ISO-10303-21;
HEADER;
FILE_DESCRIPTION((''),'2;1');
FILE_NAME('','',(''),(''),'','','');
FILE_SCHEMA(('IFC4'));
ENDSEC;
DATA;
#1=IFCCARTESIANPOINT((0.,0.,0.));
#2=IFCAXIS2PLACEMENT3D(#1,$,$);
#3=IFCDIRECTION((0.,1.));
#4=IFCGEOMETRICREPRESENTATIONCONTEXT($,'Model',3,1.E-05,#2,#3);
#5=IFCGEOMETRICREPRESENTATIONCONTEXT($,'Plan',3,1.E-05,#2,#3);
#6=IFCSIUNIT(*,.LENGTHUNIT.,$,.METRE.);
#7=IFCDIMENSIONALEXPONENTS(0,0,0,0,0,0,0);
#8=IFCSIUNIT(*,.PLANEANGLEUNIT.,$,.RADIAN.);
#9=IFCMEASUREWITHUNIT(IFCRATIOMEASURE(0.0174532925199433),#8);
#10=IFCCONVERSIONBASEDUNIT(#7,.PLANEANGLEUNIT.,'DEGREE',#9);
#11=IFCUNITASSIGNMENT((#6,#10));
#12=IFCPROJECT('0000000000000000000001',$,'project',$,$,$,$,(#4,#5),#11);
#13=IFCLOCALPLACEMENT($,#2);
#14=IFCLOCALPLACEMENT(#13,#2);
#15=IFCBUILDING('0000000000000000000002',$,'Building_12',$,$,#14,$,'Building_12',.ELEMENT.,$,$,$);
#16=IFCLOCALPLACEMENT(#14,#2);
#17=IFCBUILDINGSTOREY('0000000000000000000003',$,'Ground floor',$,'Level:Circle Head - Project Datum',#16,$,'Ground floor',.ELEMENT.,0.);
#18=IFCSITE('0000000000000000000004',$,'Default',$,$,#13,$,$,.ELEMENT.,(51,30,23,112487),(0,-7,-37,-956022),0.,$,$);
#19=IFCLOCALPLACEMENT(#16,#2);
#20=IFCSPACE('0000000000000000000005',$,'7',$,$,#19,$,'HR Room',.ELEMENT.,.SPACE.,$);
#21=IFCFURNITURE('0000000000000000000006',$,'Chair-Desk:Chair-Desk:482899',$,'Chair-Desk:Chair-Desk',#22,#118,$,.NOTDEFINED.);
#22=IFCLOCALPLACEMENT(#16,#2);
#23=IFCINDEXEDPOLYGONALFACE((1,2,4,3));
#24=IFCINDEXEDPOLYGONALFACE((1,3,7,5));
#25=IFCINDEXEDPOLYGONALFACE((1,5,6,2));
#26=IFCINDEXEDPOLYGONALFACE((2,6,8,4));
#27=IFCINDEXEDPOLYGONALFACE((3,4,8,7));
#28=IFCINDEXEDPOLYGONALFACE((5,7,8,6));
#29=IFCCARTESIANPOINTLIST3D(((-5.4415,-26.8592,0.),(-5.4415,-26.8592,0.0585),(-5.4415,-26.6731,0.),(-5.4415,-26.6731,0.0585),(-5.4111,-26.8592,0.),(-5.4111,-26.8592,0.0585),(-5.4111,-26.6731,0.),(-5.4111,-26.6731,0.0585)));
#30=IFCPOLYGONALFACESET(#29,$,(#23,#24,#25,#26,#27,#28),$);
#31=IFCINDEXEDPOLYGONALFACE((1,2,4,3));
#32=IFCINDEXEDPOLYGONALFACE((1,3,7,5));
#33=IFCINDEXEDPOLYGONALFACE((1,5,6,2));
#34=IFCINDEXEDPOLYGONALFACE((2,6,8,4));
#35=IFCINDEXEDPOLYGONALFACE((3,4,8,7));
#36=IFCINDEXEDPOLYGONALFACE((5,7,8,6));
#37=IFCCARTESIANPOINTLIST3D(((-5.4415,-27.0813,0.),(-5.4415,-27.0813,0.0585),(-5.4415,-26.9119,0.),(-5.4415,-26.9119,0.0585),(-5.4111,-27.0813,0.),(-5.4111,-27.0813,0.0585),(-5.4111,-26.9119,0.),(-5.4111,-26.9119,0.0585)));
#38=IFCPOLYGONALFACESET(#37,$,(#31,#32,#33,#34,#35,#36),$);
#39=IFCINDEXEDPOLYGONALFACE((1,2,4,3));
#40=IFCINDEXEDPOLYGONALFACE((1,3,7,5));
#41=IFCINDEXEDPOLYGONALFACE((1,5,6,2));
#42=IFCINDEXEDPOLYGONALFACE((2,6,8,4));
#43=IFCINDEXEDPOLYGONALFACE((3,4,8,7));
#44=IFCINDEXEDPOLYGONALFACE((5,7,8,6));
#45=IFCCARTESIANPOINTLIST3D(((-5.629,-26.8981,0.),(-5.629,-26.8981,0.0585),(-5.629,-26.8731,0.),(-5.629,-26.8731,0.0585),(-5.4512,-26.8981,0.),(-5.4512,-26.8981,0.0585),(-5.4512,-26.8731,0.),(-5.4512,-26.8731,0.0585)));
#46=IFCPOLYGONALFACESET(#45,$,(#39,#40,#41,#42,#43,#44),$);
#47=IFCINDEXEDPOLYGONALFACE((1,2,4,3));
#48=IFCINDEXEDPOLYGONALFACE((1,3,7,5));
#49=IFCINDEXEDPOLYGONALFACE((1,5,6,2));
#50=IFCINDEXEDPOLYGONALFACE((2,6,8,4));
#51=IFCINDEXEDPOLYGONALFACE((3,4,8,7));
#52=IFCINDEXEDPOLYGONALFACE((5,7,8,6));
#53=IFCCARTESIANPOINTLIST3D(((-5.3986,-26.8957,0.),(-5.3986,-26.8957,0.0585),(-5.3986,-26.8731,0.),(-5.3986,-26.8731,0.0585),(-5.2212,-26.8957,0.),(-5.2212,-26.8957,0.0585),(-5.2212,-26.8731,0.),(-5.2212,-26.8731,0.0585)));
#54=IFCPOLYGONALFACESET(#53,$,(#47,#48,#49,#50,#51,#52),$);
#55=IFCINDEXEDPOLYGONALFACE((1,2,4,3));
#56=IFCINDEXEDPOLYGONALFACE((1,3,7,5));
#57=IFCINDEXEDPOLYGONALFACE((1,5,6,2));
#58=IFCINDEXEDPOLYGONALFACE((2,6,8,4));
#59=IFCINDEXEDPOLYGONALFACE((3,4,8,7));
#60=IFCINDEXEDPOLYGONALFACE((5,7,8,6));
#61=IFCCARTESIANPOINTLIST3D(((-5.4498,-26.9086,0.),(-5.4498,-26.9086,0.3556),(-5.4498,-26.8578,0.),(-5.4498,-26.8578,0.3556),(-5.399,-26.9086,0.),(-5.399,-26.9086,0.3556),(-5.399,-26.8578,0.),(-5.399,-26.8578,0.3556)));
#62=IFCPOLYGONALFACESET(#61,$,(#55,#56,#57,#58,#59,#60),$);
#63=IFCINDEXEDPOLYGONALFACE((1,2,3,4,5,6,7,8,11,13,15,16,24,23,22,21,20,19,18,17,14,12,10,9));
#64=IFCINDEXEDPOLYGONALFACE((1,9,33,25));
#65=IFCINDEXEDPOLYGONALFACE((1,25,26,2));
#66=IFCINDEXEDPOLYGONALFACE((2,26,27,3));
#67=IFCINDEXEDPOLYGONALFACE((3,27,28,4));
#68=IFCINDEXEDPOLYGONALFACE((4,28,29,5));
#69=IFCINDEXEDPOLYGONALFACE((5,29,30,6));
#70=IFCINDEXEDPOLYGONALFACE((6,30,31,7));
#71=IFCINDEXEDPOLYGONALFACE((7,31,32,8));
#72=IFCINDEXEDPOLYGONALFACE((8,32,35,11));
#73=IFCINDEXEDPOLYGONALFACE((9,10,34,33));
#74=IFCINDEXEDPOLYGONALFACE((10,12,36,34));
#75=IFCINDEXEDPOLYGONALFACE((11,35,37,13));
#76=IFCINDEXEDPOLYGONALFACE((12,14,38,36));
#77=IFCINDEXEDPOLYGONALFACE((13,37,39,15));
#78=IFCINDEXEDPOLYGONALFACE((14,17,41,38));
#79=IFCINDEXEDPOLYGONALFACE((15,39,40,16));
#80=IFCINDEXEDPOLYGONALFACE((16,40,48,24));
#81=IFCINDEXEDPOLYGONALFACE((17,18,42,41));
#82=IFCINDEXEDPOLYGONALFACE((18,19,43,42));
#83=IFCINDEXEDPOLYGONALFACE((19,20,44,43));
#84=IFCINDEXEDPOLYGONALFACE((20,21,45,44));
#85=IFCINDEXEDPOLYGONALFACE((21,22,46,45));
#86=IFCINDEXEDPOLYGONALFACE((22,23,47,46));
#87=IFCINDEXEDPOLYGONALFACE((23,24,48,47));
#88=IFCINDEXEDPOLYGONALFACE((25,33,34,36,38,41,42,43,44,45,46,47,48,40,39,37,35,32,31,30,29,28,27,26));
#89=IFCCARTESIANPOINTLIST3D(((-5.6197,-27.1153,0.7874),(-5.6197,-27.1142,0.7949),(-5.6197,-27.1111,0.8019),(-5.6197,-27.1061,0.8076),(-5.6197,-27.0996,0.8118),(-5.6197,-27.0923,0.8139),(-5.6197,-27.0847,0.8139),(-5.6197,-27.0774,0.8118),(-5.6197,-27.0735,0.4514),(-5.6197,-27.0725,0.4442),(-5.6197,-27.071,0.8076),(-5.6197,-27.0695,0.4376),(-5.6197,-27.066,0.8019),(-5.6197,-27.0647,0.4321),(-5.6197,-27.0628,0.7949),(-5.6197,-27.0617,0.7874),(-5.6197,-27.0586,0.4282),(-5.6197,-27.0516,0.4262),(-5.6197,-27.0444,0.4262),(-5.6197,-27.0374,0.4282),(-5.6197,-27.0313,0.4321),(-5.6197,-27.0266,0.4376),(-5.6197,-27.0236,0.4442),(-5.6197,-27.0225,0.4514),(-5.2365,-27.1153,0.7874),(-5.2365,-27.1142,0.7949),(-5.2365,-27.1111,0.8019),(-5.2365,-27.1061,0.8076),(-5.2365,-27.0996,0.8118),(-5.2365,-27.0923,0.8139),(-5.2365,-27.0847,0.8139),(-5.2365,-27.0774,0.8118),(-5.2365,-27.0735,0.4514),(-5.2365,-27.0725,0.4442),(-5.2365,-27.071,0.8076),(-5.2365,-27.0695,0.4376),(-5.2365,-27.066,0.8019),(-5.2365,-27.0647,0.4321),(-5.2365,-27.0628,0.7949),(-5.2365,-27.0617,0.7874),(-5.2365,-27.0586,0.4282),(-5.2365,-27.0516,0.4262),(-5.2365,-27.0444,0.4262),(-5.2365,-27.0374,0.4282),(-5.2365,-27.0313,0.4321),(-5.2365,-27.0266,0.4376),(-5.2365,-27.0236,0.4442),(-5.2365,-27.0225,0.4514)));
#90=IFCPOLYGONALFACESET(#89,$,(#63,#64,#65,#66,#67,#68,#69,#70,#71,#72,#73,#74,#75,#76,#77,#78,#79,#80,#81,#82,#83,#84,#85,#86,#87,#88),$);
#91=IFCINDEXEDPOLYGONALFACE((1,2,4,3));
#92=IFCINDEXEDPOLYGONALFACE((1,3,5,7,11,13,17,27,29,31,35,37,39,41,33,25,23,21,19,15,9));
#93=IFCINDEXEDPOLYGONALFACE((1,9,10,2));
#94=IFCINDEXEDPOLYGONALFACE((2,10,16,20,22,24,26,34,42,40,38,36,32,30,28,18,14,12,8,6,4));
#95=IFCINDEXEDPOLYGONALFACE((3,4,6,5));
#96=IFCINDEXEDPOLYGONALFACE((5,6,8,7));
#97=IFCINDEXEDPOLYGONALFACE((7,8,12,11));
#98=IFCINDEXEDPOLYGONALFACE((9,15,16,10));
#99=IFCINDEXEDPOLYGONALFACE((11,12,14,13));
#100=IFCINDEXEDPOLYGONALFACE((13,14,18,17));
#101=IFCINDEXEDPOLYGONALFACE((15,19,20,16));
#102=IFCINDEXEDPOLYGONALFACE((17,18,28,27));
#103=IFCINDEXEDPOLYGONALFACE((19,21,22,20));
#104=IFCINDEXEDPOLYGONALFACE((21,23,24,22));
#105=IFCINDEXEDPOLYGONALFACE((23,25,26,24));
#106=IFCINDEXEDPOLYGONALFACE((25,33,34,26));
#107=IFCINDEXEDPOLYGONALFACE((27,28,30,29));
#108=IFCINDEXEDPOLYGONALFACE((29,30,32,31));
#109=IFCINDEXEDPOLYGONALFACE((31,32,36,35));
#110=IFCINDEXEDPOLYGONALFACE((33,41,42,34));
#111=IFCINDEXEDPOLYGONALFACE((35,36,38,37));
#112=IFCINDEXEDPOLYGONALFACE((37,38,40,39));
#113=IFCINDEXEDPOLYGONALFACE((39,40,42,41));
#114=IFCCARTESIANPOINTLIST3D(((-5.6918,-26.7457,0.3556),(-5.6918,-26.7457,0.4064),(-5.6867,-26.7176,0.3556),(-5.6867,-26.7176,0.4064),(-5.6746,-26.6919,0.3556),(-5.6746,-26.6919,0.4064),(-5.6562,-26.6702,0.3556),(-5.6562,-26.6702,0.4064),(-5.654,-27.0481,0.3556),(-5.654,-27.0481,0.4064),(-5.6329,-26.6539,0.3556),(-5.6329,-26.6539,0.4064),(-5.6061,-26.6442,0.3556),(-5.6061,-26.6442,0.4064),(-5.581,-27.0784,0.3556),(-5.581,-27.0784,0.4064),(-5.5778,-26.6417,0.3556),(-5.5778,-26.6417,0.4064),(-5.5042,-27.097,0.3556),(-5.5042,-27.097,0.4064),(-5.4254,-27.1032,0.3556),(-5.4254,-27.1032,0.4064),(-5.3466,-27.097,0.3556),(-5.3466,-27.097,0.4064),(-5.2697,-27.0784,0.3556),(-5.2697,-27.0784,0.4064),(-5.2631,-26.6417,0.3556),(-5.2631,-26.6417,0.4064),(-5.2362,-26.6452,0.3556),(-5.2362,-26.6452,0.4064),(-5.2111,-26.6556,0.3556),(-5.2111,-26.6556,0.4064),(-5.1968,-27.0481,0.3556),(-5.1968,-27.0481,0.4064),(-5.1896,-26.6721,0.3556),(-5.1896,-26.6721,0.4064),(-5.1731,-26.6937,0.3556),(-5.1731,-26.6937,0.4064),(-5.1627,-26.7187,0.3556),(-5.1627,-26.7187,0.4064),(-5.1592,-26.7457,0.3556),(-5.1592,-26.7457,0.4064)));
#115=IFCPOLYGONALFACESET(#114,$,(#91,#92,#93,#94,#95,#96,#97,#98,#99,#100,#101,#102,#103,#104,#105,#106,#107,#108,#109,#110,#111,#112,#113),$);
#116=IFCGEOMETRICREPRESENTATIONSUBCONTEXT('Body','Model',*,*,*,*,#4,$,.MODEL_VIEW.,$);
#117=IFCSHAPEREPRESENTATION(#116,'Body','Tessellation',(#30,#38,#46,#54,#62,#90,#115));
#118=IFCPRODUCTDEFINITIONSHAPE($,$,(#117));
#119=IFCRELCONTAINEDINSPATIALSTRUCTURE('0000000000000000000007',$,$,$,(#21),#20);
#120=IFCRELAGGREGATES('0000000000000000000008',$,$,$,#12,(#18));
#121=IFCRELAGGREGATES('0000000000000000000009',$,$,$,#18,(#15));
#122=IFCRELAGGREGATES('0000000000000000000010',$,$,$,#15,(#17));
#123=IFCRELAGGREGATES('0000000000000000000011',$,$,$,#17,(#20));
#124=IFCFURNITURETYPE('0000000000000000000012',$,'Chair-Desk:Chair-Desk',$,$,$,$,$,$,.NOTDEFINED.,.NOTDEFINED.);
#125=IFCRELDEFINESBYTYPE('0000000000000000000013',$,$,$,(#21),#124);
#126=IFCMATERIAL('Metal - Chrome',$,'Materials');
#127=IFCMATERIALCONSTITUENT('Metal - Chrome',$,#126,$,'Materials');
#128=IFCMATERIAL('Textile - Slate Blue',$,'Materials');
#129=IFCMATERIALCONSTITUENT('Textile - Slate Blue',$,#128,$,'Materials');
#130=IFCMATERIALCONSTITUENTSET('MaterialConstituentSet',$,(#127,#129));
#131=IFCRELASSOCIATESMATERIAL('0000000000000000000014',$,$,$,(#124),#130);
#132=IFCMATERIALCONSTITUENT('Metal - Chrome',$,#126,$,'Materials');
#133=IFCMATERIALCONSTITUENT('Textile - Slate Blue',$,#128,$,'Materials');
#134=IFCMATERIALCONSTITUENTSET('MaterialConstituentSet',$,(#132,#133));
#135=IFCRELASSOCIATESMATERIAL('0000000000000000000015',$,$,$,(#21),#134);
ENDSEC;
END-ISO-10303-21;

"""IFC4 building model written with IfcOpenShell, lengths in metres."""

from ifc_helpers import new_model, entity, si_unit, converted_unit, direction, frame, origin, place, context, subcontext, project, spatial, line, arc, indexed_curve, outline, extrude, source, transform, mapped, material, constituent, constituent_set, type_object, type_shapes, element, save


model = new_model("IFC4")

# Units and contexts
model_context = context("Model", 3, precision=1e-05, world=origin(), true_north=direction((0.0, 1.0)))
plan_context = context("Plan", 3, precision=1e-05, world=origin(), true_north=direction((0.0, 1.0)))
body_context = subcontext(model_context, "Body", "Model", "MODEL_VIEW")
ifc_project = project(units=[si_unit("LENGTHUNIT", "METRE"), converted_unit("PLANEANGLEUNIT", "DEGREE", entity("IfcRatioMeasure", 0.0174532925199433), si_unit("PLANEANGLEUNIT", "RADIAN"), dimensions=[0, 0, 0, 0, 0, 0, 0])], contexts=[model_context, plan_context])

# Site, building, storey
site_placement = place(None, origin())
site = spatial("IfcSite", under=ifc_project, at=site_placement, Name="Default", CompositionType="ELEMENT", RefLatitude=(51, 30, 23, 112487), RefLongitude=(0, -7, -37, -956022), RefElevation=0.0)
building_placement = place(site_placement, origin())
building = spatial("IfcBuilding", under=site, at=building_placement, Name="Building_12", LongName="Building_12", CompositionType="ELEMENT")
storey_placement = place(building_placement, origin())
storey = spatial("IfcBuildingStorey", under=building, at=storey_placement, Name="Ground floor", ObjectType="Level:Circle Head - Project Datum", LongName="Ground floor", CompositionType="ELEMENT", Elevation=0.0)

# Shared definitions
space_placement = place(storey_placement, origin())
space = spatial("IfcSpace", under=storey, at=space_placement, Name="7", LongName="HR Room", CompositionType="ELEMENT", PredefinedType="SPACE")

# Furniture
ifc_material_1 = material(Name="Metal - Chrome", Category="Materials")
ifc_constituent_1 = constituent(ifc_material_1, Name="Metal - Chrome", Category="Materials")
ifc_material_2 = material(Name="Textile - Slate Blue", Category="Materials")
ifc_constituent_2 = constituent(ifc_material_2, Name="Textile - Slate Blue", Category="Materials")
ifc_constituent_set_1 = constituent_set(constituents=[ifc_constituent_1, ifc_constituent_2], Name="MaterialConstituentSet")
ifc_constituent_3 = constituent(ifc_material_1, Name="Metal - Chrome", Category="Materials")
ifc_constituent_4 = constituent(ifc_material_2, Name="Textile - Slate Blue", Category="Materials")
ifc_constituent_set_2 = constituent_set(constituents=[ifc_constituent_3, ifc_constituent_4], Name="MaterialConstituentSet")
furniture_type = type_object("IfcFurnitureType", Name="Chair-Desk:Chair-Desk", AssemblyPlace="NOTDEFINED", PredefinedType="NOTDEFINED", material=ifc_constituent_set_2)
shared_shape_1 = source(origin(), body_context, "Body", "SweptSolid", [
    extrude(outline(indexed_curve([(-0.0152, -0.093), (0.0152, -0.093), (0.0152, 0.093), (-0.0152, 0.093), (-0.0152, -0.093)], self_intersect=False)), frame((-0.0009, 0.2819, 0.0)), (0.0, 0.0, 1.0), 0.0585),
    extrude(outline(indexed_curve([(-0.0152, -0.0847), (0.0152, -0.0847), (0.0152, 0.0847), (-0.0152, 0.0847), (-0.0152, -0.0847)], self_intersect=False)), frame((-0.0009, 0.0515, 0.0), z_axis=(0.0, 0.0, 1.0), x_axis=(-1.0, 0.0, 0.0)), (0.0, 0.0, 1.0), 0.0585),
    extrude(outline(indexed_curve([(-0.0125, -0.0889), (0.0125, -0.0889), (0.0125, 0.0889), (-0.0125, 0.0889), (-0.0125, -0.0889)], self_intersect=False)), frame((-0.1148, 0.1625, 0.0), z_axis=(0.0, 0.0, 1.0), x_axis=(0.0, -1.0, 0.0)), (0.0, 0.0, 1.0), 0.0585),
    extrude(outline(indexed_curve([(-0.0887, -0.0113), (0.0887, -0.0113), (0.0887, 0.0113), (-0.0887, 0.0113), (-0.0887, -0.0113)], self_intersect=False)), frame((0.1155, 0.1637, 0.0), z_axis=(0.0, 0.0, 1.0), x_axis=(-1.0, 0.0, 0.0)), (0.0, 0.0, 1.0), 0.0585),
    extrude(outline(indexed_curve([(-0.0254, -0.0254), (0.0254, -0.0254), (0.0254, 0.0254), (-0.0254, 0.0254), (-0.0254, -0.0254)], self_intersect=False)), frame((0.0009, 0.1649, 0.0), z_axis=(0.0, 0.0, 1.0), x_axis=(-1.0, 0.0, 0.0)), (0.0, 0.0, 1.0), 0.3556),
    extrude(outline(indexed_curve([(0.0065, 0.168), (-0.0202, 0.1948), (-0.047, 0.168), (-0.0052, -0.168), (0.0202, -0.1935), (0.0457, -0.168)], segments=[arc(1, 2, 3), line(3, 4), arc(4, 5, 6), line(6, 1)], self_intersect=False)), frame((-0.1944, -0.0202, 0.6194), z_axis=(1.0, 0.0, 0.0), x_axis=(0.0, 1.0, 0.0)), (0.0, 0.0, 1.0), 0.3833),
    extrude(outline(indexed_curve([(-0.0989, -0.2577), (0.2059, -0.2577), (0.2889, -0.0377), (0.2626, 0.1959), (-0.0328, 0.2708), (-0.1095, 0.2497), (-0.1489, 0.1805), (-0.1879, -0.1317), (-0.1694, -0.2131)], segments=[line(1, 2), arc(2, 3, 4), line(4, 5), arc(5, 6, 7), line(7, 8), arc(8, 9, 1)], self_intersect=False)), frame((0.0016, 0.2363, 0.3556), z_axis=(0.0, 0.0, 1.0), x_axis=(0.124035, -0.992278, 0.0)), (0.0, 0.0, 1.0), 0.0508),
])
type_shapes(furniture_type, [shared_shape_1])
furniture_1_placement = place(space_placement, frame((-5.4254, -27.0481, 0.0)))
element("IfcFurniture", 1, at=furniture_1_placement, inside=space, type_object=furniture_type, material=ifc_constituent_set_1, Name="Chair-Desk:Chair-Desk:482899", ObjectType="Chair-Desk:Chair-Desk", PredefinedType="NOTDEFINED", context=body_context, shape_type="MappedRepresentation", body=[
    mapped(shared_shape_1, transform((0.0, 0.0, 0.0), scale=1.0)),
])

save(model, "model.ifc")
